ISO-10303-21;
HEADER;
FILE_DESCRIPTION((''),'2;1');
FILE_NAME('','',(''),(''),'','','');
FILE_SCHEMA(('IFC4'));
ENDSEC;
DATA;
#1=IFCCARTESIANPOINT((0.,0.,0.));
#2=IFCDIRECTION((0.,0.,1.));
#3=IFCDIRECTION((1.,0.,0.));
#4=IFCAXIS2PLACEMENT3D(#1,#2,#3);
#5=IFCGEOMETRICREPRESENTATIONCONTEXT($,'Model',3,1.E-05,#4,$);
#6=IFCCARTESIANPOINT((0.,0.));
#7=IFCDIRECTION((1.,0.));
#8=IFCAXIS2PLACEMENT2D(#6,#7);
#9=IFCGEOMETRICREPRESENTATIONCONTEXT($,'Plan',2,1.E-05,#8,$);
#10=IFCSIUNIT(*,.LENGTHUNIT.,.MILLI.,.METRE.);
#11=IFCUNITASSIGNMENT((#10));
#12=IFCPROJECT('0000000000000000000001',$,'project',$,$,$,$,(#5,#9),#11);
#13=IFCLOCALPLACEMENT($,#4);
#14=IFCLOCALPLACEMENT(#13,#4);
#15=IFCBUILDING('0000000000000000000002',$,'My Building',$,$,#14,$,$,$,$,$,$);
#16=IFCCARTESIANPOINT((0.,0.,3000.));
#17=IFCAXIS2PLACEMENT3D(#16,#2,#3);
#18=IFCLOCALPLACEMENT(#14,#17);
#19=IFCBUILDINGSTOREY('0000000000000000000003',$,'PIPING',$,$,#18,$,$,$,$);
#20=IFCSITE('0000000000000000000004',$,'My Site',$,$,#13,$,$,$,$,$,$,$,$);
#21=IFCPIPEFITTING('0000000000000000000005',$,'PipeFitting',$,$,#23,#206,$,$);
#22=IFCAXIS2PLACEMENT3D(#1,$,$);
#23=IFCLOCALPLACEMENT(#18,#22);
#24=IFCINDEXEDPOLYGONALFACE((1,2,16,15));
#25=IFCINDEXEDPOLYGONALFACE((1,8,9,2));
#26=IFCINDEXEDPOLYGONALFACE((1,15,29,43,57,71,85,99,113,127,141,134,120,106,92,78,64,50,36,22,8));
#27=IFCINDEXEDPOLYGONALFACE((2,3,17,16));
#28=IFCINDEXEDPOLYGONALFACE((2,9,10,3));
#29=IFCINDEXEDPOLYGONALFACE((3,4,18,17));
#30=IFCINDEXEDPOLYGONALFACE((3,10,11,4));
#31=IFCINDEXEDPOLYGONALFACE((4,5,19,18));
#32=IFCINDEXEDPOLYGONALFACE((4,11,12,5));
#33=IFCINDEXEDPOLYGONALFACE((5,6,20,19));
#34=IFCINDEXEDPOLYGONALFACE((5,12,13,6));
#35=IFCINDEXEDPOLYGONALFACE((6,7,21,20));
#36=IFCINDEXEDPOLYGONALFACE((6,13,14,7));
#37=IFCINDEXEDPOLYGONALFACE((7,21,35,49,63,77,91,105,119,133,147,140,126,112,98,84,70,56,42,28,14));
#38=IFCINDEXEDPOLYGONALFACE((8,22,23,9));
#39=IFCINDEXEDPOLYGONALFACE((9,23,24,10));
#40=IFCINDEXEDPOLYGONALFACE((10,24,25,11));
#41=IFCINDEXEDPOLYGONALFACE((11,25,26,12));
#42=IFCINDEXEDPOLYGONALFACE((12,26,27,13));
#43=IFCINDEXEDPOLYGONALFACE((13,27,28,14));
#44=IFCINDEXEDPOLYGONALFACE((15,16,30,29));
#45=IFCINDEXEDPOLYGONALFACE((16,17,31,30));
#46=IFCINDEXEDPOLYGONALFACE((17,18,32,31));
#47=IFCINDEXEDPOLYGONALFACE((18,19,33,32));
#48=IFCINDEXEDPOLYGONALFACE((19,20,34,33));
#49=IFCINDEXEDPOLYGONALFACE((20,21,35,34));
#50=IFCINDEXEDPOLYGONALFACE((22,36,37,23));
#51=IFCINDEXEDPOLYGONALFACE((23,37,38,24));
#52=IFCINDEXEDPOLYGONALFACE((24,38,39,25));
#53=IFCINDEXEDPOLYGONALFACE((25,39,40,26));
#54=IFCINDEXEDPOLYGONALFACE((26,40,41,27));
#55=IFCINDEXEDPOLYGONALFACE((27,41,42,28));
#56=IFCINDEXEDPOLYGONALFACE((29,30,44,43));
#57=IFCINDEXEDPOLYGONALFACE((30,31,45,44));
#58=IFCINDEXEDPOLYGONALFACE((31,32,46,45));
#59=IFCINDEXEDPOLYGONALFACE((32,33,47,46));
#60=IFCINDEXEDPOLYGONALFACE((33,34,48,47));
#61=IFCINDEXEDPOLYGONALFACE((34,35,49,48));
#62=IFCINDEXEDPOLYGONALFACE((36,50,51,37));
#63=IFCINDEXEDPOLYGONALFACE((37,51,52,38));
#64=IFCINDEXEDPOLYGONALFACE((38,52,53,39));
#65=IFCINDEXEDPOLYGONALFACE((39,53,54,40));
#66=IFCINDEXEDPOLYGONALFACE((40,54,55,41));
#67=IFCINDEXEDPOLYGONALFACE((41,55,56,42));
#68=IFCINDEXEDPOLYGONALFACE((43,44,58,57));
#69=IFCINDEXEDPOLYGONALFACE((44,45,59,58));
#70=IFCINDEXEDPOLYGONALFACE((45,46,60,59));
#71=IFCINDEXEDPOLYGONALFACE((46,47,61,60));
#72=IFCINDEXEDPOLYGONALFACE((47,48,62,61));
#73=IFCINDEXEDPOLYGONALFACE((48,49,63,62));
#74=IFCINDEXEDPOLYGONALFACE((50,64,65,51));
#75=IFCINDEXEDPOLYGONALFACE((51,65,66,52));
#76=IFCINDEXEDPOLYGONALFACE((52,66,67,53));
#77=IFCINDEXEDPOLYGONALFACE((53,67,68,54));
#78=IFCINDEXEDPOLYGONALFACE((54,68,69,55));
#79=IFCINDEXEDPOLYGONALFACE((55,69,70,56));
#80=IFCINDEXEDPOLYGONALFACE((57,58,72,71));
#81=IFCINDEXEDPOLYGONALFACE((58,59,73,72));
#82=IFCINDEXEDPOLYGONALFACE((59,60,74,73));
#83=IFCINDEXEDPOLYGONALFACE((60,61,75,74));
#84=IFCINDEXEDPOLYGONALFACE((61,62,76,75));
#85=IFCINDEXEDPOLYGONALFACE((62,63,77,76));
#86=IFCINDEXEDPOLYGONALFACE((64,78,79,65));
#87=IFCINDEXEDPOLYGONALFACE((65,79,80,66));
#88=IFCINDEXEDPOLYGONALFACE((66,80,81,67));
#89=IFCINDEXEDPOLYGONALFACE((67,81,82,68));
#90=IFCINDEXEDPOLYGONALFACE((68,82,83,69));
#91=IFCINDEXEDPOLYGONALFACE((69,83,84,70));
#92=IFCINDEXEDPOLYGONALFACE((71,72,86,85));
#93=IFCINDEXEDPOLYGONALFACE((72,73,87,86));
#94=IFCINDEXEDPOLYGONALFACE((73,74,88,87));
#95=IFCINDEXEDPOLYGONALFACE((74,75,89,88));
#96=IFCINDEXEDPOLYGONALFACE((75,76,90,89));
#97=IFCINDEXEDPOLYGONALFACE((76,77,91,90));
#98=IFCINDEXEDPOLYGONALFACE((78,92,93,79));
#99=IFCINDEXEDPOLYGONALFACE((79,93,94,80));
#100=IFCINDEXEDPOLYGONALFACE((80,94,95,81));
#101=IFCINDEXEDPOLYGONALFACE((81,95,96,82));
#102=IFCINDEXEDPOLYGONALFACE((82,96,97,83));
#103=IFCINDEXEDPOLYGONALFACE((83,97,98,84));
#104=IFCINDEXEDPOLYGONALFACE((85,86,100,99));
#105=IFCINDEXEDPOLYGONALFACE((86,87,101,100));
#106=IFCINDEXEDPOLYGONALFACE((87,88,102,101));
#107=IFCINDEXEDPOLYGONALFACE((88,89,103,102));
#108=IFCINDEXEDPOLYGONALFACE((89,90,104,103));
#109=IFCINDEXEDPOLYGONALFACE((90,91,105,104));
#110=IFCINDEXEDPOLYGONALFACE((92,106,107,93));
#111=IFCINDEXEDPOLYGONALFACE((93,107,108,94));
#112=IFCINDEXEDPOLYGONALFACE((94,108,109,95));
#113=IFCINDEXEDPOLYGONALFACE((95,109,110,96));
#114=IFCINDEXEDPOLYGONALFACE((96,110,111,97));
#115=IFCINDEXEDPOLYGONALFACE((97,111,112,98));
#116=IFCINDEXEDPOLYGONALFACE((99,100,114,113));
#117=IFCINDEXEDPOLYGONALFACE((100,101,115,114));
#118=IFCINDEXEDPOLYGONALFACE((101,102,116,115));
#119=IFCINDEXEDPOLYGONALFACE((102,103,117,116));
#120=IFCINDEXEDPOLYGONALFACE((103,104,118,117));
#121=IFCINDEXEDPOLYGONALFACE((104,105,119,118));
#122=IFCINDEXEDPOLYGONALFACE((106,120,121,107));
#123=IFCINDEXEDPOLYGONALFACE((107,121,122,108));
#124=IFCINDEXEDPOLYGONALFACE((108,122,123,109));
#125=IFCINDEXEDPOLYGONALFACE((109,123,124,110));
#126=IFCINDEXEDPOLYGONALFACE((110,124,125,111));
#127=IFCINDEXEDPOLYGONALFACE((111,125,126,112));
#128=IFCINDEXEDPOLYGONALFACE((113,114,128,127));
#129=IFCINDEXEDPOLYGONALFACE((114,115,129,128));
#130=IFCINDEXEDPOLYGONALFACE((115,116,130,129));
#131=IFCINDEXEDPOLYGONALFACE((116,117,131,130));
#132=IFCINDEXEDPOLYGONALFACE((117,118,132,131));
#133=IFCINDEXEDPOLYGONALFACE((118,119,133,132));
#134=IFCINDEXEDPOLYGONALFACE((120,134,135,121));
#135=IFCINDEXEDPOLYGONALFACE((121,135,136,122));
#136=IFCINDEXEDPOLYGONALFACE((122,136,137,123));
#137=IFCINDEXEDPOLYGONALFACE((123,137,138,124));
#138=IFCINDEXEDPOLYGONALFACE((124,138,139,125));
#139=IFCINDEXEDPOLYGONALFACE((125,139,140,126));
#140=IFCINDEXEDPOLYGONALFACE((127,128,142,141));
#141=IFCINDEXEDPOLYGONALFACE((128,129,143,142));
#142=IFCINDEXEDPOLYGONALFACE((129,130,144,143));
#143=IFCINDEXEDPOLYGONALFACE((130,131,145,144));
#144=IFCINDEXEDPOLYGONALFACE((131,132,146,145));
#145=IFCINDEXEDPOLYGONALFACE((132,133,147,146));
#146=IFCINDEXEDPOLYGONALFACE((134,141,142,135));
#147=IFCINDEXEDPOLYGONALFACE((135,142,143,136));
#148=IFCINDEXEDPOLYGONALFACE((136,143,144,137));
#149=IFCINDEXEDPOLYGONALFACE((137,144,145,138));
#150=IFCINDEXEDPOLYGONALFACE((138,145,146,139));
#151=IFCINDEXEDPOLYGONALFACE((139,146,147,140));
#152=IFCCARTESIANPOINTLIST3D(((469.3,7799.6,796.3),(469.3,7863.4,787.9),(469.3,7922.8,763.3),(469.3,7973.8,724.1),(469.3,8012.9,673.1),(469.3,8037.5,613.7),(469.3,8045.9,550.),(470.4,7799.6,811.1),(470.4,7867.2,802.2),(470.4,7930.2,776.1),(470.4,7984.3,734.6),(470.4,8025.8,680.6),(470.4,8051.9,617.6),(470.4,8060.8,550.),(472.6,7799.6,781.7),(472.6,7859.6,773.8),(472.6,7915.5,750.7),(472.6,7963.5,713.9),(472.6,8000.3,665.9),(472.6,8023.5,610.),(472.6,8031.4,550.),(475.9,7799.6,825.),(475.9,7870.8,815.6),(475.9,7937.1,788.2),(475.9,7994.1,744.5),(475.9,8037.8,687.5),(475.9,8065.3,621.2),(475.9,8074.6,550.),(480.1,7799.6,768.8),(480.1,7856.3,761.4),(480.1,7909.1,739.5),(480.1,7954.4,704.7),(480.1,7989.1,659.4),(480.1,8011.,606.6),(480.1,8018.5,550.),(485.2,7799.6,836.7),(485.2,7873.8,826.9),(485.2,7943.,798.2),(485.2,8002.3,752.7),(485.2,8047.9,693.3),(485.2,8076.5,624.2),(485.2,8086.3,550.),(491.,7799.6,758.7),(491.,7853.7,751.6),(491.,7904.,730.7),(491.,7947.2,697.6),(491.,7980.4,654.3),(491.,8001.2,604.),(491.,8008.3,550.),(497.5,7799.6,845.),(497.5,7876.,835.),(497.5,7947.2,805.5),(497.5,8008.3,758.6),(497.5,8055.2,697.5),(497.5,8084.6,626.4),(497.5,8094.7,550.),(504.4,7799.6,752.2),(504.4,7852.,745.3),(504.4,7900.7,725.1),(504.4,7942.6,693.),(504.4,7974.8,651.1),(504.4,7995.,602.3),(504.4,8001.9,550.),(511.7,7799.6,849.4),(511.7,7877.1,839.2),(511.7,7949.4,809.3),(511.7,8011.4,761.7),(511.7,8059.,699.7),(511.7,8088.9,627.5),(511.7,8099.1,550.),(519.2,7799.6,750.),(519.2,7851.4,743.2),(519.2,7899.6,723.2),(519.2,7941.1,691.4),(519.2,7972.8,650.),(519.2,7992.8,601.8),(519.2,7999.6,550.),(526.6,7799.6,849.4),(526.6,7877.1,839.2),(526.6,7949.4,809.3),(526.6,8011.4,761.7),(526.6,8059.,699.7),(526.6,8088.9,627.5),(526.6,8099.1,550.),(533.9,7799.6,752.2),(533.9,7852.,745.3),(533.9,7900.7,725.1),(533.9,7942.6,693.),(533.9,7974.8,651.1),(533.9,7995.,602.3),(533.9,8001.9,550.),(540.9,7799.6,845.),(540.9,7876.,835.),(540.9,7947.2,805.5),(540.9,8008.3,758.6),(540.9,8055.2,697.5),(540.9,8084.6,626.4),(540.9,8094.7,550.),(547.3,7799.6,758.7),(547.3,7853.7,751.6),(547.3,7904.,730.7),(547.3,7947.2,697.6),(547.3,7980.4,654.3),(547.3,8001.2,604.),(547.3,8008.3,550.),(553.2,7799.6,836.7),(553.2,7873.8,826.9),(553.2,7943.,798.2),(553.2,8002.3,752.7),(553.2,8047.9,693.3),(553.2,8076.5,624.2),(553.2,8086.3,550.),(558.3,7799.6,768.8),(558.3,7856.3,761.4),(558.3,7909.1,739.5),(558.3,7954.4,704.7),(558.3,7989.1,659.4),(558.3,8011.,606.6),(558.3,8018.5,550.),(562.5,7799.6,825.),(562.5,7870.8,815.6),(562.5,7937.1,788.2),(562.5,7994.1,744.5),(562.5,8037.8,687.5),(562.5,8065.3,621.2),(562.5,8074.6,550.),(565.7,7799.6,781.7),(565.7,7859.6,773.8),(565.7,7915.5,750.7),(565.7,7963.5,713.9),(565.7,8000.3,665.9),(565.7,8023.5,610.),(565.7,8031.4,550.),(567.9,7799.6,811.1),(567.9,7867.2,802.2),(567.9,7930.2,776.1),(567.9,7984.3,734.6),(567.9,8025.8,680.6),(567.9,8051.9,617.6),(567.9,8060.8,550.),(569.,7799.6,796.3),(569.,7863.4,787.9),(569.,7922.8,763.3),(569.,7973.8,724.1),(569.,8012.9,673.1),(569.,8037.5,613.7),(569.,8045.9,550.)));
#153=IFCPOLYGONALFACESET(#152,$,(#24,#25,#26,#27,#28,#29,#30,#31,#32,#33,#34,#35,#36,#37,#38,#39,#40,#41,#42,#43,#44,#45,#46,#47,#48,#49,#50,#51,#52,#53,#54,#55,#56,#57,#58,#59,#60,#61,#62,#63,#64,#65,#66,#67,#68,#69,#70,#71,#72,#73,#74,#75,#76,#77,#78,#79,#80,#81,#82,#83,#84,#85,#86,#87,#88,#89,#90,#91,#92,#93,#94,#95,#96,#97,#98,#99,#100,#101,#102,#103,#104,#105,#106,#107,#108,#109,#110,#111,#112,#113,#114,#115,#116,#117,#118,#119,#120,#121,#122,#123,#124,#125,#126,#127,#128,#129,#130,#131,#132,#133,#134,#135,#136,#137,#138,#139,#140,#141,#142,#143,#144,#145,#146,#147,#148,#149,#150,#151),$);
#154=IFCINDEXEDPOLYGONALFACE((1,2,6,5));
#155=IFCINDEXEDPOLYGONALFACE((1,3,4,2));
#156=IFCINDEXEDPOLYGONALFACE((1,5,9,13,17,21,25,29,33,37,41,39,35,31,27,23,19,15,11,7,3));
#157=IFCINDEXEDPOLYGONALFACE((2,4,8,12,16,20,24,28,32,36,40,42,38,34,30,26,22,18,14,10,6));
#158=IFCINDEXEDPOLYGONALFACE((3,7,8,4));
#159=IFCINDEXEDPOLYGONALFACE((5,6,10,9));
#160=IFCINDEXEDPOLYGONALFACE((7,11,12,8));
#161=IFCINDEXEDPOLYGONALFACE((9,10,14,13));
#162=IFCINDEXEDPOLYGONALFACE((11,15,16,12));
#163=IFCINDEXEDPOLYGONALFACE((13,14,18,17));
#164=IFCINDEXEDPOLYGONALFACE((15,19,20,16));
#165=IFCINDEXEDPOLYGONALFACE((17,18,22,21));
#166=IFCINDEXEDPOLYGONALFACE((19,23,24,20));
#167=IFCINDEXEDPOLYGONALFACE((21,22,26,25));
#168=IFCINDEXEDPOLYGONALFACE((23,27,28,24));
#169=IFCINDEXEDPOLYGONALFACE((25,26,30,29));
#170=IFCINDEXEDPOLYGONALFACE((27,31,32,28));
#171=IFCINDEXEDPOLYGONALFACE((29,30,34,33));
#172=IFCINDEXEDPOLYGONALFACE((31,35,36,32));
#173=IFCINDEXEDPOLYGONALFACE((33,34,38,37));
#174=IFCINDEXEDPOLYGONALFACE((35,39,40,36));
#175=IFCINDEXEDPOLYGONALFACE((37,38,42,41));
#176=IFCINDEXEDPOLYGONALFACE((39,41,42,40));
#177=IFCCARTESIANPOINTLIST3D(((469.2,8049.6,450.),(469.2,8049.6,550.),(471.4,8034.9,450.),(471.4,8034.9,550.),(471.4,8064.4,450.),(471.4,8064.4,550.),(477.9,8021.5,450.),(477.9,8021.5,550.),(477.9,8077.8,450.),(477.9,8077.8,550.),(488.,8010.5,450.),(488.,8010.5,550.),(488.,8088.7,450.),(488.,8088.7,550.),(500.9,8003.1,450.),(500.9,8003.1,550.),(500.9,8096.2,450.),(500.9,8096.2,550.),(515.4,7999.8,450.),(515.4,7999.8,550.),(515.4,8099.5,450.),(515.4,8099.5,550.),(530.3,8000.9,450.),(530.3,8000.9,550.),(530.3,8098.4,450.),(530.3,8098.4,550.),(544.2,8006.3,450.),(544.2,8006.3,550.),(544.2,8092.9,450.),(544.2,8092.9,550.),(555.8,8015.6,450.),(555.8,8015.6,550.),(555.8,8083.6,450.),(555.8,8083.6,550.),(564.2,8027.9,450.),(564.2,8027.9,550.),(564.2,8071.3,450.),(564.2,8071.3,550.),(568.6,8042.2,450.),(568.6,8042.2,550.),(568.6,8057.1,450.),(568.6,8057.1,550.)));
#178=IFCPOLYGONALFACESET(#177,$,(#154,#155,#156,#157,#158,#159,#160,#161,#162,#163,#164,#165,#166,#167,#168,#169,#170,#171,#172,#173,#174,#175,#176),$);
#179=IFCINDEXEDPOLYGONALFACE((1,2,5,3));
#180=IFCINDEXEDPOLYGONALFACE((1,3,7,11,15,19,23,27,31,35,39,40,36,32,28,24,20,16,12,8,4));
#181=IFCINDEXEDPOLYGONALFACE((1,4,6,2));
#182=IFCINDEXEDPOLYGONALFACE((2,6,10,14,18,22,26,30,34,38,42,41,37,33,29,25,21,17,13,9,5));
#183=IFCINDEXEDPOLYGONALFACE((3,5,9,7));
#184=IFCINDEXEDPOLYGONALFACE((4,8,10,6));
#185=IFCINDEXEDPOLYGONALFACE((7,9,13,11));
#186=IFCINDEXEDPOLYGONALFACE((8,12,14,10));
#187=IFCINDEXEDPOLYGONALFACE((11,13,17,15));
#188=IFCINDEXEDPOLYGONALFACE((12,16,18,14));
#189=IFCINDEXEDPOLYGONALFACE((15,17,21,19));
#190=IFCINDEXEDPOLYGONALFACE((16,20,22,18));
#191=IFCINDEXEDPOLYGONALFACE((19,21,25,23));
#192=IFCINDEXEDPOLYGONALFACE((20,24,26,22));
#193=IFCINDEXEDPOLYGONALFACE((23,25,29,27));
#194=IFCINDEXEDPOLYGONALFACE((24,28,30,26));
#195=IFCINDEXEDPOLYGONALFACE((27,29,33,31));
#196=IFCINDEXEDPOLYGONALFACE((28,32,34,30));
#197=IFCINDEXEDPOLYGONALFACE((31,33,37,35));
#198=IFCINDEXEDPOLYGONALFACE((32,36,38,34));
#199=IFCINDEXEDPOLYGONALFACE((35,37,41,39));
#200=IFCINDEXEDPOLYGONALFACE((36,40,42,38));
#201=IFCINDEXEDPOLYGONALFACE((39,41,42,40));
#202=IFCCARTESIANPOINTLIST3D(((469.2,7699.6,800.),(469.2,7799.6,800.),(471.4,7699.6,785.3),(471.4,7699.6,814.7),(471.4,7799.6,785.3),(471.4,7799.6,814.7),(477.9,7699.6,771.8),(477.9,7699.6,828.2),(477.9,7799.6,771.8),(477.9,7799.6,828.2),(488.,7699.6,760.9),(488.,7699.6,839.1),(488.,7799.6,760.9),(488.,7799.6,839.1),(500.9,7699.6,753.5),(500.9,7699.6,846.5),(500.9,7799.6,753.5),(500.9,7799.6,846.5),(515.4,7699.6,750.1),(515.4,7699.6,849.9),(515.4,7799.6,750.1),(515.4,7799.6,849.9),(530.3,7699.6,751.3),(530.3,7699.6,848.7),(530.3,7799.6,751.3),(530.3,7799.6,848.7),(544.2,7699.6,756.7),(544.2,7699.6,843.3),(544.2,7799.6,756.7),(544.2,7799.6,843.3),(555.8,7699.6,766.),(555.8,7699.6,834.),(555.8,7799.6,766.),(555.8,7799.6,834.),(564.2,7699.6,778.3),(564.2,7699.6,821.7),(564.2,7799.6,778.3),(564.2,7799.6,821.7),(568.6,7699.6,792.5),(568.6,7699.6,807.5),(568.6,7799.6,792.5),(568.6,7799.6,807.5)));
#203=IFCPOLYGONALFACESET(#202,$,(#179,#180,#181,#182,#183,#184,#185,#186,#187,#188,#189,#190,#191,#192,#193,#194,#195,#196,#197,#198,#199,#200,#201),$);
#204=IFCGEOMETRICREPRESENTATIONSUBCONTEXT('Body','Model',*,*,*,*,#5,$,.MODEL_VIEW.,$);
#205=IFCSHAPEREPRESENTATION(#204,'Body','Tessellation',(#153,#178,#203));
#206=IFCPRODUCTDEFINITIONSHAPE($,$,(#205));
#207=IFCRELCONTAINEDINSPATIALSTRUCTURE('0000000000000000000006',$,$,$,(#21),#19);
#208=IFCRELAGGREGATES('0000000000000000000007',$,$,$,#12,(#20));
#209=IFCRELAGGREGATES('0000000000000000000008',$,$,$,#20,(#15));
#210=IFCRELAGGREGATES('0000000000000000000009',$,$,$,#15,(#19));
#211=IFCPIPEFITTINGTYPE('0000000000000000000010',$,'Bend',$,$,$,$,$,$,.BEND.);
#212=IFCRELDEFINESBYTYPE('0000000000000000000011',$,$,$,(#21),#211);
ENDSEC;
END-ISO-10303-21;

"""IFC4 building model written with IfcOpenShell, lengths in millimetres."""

from ifc_helpers import new_model, entity, si_unit, frame, origin_with_axes, origin_2d_with_axis, place, context, subcontext, project, spatial, circle, extrude, source, transform, mapped, type_object, type_shapes, element, save


model = new_model("IFC4")

# Units and contexts
model_context = context("Model", 3, precision=1e-05, world=origin_with_axes())
plan_context = context("Plan", 2, precision=1e-05, world=origin_2d_with_axis())
body_context = subcontext(model_context, "Body", "Model", "MODEL_VIEW")
ifc_project = project(units=[si_unit("LENGTHUNIT", "METRE", prefix="MILLI")], contexts=[model_context, plan_context])

# Site, building, storey
site_placement = place(None, origin_with_axes())
site = spatial("IfcSite", under=ifc_project, at=site_placement, Name="My Site")
building_placement = place(site_placement, origin_with_axes())
building = spatial("IfcBuilding", under=site, at=building_placement, Name="My Building")
storey_placement = place(building_placement, frame((0.0, 0.0, 3000.0), z_axis=(0.0, 0.0, 1.0), x_axis=(1.0, 0.0, 0.0)))
storey = spatial("IfcBuildingStorey", under=building, at=storey_placement, Name="PIPING")

# Pipe fitting
pipe_fitting_type = type_object("IfcPipeFittingType", Name="Bend", PredefinedType="BEND")
shared_shape = source(origin_with_axes(), body_context, "Body", "SolidModel", [
    entity("IfcSweptDiskSolid", entity("IfcIndexedPolyCurve", entity("IfcCartesianPointList3D", [[0.0, 0.0, 100.0], [0.0, 73.2, 276.8], [0.0, 250.0, 350.0]]), [entity("IfcArcIndex", [1, 2, 3])]), 50.0),
    extrude(circle(Radius=50.0), origin_with_axes(), (0.0, 0.0, 1.0), 100.0),
    extrude(circle(Radius=50.0), frame((0.0, 250.0, 350.0), z_axis=(0.0, 1.0, 0.0), x_axis=(1.0, 0.0, 0.0)), (0.0, 0.0, 1.0), 100.0),
])
type_shapes(pipe_fitting_type, [shared_shape])
pipe_fitting_placement = place(storey_placement, frame((519.2, 8049.6, 450.0), z_axis=(0.0, 0.0, 1.0), x_axis=(-1.0, 0.0, 0.0)))
element("IfcPipeFitting", 1, at=pipe_fitting_placement, inside=storey, type_object=pipe_fitting_type, Name="PipeFitting", context=body_context, shape_type="MappedRepresentation", body=[
    mapped(shared_shape, transform((0.0, 0.0, 0.0), x_axis=(1.0, 0.0, 0.0), y_axis=(0.0, 1.0, 0.0), z_axis=(0.0, 0.0, 1.0), scale=1.0)),
])

save(model, "model.ifc")
